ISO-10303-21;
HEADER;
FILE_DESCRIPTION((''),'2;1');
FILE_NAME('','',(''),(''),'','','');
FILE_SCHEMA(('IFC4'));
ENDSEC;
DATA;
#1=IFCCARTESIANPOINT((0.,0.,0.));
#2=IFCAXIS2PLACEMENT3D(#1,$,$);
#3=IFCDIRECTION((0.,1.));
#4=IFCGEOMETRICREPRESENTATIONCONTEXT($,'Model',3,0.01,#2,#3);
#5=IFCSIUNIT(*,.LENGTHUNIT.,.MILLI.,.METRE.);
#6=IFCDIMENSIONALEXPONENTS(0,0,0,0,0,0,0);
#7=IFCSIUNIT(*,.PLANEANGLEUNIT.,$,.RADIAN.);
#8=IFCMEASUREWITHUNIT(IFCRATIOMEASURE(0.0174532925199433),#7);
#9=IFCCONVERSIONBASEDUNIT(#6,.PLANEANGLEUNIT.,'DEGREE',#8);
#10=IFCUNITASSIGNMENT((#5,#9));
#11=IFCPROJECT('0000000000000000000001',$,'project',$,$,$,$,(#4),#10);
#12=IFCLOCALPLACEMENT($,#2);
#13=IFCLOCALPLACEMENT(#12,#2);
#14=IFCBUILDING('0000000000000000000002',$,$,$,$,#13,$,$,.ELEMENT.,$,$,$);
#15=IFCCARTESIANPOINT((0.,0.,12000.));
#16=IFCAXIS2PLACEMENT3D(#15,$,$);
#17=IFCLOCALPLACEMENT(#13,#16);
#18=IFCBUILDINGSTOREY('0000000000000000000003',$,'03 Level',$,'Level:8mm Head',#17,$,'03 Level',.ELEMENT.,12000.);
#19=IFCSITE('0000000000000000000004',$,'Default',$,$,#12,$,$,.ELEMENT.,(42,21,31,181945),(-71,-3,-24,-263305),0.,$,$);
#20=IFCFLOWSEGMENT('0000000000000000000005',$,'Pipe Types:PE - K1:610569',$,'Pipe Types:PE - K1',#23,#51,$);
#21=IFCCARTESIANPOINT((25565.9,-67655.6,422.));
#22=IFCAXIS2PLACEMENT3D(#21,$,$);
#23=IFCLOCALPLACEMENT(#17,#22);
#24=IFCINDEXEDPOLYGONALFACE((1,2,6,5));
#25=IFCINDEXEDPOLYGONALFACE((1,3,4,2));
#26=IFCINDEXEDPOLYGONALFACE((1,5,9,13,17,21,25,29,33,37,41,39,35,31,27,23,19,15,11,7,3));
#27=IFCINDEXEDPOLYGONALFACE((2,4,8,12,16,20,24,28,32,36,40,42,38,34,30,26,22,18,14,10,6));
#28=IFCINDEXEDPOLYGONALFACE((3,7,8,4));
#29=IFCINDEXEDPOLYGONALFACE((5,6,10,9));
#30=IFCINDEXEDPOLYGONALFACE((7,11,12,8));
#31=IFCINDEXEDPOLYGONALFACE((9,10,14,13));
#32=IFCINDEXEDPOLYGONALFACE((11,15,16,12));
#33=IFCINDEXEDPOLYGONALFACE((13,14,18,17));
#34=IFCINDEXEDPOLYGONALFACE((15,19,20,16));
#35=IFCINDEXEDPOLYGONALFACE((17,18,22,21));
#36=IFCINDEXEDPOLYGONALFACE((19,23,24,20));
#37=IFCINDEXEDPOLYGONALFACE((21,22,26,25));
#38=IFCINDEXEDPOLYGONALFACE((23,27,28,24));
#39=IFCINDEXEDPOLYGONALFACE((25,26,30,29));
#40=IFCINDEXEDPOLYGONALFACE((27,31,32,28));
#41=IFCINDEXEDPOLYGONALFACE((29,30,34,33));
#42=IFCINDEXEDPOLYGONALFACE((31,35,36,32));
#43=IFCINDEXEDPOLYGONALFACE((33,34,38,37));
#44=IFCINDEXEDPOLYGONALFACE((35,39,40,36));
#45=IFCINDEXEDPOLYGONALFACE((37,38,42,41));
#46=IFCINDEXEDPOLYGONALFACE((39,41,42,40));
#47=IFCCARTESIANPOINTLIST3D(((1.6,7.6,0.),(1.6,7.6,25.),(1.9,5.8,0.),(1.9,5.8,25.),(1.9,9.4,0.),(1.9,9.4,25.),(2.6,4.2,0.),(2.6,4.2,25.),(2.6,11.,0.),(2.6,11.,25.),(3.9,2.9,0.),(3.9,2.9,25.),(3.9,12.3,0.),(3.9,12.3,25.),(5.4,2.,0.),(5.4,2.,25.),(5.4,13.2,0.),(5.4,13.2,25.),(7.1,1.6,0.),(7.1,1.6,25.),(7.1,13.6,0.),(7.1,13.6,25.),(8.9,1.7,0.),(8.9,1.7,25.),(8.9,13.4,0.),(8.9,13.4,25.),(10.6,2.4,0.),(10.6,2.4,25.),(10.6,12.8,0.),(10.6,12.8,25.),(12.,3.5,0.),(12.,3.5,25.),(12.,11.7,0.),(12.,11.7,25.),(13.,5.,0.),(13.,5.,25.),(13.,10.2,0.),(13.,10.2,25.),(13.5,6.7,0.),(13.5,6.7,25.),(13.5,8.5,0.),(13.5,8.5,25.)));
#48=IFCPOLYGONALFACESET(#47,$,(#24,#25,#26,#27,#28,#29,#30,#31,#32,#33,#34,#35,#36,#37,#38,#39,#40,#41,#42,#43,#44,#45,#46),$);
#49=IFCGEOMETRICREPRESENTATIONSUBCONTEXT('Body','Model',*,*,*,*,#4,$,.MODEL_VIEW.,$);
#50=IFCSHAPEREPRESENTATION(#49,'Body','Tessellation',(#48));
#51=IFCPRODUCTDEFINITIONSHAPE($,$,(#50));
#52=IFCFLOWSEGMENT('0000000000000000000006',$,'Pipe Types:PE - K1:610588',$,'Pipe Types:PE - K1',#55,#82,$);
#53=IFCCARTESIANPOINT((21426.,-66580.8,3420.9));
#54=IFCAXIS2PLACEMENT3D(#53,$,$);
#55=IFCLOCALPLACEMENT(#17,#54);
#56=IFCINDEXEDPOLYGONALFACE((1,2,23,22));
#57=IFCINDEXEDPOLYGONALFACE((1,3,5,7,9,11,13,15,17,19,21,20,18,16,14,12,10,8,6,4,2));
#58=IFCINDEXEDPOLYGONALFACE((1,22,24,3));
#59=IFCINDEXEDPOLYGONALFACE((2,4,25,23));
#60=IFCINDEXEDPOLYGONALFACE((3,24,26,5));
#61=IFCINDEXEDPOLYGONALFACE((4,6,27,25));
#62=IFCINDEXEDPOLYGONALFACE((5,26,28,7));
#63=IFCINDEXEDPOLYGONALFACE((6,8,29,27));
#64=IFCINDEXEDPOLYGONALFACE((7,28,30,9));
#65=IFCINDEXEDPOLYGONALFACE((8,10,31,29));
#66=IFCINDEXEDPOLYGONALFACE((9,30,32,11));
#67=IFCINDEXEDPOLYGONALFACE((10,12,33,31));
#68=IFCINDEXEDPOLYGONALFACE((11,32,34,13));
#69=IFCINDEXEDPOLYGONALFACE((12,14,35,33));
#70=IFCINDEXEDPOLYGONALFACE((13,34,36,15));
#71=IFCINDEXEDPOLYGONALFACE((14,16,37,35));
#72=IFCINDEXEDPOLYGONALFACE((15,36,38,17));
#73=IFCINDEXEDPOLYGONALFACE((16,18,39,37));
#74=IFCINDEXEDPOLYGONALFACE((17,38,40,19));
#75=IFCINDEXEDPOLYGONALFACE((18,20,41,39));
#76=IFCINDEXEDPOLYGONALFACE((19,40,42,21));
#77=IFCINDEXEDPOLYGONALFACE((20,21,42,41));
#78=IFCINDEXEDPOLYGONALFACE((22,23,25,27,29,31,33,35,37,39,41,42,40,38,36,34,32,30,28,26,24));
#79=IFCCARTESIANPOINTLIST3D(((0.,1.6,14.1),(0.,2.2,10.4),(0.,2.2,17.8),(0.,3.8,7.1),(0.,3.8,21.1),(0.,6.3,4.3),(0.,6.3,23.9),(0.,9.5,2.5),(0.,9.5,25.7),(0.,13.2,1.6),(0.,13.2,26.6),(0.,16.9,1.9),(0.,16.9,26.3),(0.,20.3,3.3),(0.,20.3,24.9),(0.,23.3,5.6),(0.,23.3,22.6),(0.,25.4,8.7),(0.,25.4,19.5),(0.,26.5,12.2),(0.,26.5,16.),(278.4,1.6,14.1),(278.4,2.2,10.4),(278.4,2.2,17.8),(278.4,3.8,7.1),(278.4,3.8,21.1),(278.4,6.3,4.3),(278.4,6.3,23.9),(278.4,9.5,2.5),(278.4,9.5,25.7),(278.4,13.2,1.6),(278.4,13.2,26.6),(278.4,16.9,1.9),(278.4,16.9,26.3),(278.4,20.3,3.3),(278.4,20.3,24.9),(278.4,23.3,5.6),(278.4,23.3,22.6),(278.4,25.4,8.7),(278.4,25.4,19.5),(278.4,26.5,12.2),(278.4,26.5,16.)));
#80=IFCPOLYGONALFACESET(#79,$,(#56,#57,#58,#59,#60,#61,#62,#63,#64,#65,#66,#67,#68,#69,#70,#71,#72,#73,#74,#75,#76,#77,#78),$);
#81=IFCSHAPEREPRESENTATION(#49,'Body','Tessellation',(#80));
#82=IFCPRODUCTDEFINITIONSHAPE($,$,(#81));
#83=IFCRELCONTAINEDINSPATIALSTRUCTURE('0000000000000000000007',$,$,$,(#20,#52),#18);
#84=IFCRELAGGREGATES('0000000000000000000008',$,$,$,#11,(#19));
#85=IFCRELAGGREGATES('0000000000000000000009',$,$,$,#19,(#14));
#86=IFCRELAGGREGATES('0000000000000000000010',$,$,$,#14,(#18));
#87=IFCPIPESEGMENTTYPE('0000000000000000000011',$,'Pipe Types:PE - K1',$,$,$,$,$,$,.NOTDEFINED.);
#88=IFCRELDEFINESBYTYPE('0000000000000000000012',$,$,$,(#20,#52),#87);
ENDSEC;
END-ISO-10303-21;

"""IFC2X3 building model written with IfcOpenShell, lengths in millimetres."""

from ifc_helpers import new_model, entity, si_unit, converted_unit, direction, frame, frame_2d, origin, origin_2d_with_axis, place, context, subcontext, project, spatial, circle, extrude, type_object, element, save


model = new_model("IFC2X3")

# Units and contexts
model_context = context("Model", 3, precision=0.01, world=origin(), true_north=direction((0.0, 1.0)))
body_context = subcontext(model_context, "Body", "Model", "MODEL_VIEW")
ifc_project = project(units=[si_unit("LENGTHUNIT", "METRE", prefix="MILLI"), converted_unit("PLANEANGLEUNIT", "DEGREE", entity("IfcRatioMeasure", 0.0174532925199433), si_unit("PLANEANGLEUNIT", "RADIAN"), dimensions=[0, 0, 0, 0, 0, 0, 0])], contexts=[model_context])

# Site, building, storey
site_placement = place(None, origin())
site = spatial("IfcSite", under=ifc_project, at=site_placement, Name="Default", CompositionType="ELEMENT", RefLatitude=(42, 21, 31, 181945), RefLongitude=(-71, -3, -24, -263305), RefElevation=0.0)
building_placement = place(site_placement, origin())
building = spatial("IfcBuilding", under=site, at=building_placement, CompositionType="ELEMENT")
storey_placement = place(building_placement, frame((0.0, 0.0, 12000.0)))
storey = spatial("IfcBuildingStorey", under=building, at=storey_placement, Name="03 Level", ObjectType="Level:8mm Head", LongName="03 Level", CompositionType="ELEMENT", Elevation=12000.0)

# Flow segments
pipe_segment_type = type_object("IfcPipeSegmentType", Name="Pipe Types:PE - K1", PredefinedType="NOTDEFINED")
flow_segment_1_placement = place(storey_placement, frame((25565.9, -67655.6, 422.0)))
element("IfcFlowSegment", 1, at=flow_segment_1_placement, inside=storey, type_object=pipe_segment_type, Name="Pipe Types:PE - K1:610569", ObjectType="Pipe Types:PE - K1", context=body_context, shape_type="SweptSolid", body=[
    extrude(circle(Radius=6.0, at=origin_2d_with_axis()), frame((7.6, 7.6, 0.0), z_axis=(0.0, 0.0, 1.0), x_axis=(-1.0, 0.0, 0.0)), (0.0, 0.0, 1.0), 25.0),
])
flow_segment_2_placement = place(storey_placement, frame((21426.0, -66580.8, 3420.9)))
element("IfcFlowSegment", 2, at=flow_segment_2_placement, inside=storey, type_object=pipe_segment_type, Name="Pipe Types:PE - K1:610588", ObjectType="Pipe Types:PE - K1", context=body_context, shape_type="SweptSolid", body=[
    extrude(circle(Radius=12.5, at=frame_2d((0.0, 0.0), x_axis=(1.0, 0.0))), frame((0.0, 14.1, 14.1), z_axis=(1.0, 0.0, 0.0), x_axis=(0.0, -1.0, 0.0)), (0.0, 0.0, 1.0), 278.4),
])

save(model, "model.ifc")
